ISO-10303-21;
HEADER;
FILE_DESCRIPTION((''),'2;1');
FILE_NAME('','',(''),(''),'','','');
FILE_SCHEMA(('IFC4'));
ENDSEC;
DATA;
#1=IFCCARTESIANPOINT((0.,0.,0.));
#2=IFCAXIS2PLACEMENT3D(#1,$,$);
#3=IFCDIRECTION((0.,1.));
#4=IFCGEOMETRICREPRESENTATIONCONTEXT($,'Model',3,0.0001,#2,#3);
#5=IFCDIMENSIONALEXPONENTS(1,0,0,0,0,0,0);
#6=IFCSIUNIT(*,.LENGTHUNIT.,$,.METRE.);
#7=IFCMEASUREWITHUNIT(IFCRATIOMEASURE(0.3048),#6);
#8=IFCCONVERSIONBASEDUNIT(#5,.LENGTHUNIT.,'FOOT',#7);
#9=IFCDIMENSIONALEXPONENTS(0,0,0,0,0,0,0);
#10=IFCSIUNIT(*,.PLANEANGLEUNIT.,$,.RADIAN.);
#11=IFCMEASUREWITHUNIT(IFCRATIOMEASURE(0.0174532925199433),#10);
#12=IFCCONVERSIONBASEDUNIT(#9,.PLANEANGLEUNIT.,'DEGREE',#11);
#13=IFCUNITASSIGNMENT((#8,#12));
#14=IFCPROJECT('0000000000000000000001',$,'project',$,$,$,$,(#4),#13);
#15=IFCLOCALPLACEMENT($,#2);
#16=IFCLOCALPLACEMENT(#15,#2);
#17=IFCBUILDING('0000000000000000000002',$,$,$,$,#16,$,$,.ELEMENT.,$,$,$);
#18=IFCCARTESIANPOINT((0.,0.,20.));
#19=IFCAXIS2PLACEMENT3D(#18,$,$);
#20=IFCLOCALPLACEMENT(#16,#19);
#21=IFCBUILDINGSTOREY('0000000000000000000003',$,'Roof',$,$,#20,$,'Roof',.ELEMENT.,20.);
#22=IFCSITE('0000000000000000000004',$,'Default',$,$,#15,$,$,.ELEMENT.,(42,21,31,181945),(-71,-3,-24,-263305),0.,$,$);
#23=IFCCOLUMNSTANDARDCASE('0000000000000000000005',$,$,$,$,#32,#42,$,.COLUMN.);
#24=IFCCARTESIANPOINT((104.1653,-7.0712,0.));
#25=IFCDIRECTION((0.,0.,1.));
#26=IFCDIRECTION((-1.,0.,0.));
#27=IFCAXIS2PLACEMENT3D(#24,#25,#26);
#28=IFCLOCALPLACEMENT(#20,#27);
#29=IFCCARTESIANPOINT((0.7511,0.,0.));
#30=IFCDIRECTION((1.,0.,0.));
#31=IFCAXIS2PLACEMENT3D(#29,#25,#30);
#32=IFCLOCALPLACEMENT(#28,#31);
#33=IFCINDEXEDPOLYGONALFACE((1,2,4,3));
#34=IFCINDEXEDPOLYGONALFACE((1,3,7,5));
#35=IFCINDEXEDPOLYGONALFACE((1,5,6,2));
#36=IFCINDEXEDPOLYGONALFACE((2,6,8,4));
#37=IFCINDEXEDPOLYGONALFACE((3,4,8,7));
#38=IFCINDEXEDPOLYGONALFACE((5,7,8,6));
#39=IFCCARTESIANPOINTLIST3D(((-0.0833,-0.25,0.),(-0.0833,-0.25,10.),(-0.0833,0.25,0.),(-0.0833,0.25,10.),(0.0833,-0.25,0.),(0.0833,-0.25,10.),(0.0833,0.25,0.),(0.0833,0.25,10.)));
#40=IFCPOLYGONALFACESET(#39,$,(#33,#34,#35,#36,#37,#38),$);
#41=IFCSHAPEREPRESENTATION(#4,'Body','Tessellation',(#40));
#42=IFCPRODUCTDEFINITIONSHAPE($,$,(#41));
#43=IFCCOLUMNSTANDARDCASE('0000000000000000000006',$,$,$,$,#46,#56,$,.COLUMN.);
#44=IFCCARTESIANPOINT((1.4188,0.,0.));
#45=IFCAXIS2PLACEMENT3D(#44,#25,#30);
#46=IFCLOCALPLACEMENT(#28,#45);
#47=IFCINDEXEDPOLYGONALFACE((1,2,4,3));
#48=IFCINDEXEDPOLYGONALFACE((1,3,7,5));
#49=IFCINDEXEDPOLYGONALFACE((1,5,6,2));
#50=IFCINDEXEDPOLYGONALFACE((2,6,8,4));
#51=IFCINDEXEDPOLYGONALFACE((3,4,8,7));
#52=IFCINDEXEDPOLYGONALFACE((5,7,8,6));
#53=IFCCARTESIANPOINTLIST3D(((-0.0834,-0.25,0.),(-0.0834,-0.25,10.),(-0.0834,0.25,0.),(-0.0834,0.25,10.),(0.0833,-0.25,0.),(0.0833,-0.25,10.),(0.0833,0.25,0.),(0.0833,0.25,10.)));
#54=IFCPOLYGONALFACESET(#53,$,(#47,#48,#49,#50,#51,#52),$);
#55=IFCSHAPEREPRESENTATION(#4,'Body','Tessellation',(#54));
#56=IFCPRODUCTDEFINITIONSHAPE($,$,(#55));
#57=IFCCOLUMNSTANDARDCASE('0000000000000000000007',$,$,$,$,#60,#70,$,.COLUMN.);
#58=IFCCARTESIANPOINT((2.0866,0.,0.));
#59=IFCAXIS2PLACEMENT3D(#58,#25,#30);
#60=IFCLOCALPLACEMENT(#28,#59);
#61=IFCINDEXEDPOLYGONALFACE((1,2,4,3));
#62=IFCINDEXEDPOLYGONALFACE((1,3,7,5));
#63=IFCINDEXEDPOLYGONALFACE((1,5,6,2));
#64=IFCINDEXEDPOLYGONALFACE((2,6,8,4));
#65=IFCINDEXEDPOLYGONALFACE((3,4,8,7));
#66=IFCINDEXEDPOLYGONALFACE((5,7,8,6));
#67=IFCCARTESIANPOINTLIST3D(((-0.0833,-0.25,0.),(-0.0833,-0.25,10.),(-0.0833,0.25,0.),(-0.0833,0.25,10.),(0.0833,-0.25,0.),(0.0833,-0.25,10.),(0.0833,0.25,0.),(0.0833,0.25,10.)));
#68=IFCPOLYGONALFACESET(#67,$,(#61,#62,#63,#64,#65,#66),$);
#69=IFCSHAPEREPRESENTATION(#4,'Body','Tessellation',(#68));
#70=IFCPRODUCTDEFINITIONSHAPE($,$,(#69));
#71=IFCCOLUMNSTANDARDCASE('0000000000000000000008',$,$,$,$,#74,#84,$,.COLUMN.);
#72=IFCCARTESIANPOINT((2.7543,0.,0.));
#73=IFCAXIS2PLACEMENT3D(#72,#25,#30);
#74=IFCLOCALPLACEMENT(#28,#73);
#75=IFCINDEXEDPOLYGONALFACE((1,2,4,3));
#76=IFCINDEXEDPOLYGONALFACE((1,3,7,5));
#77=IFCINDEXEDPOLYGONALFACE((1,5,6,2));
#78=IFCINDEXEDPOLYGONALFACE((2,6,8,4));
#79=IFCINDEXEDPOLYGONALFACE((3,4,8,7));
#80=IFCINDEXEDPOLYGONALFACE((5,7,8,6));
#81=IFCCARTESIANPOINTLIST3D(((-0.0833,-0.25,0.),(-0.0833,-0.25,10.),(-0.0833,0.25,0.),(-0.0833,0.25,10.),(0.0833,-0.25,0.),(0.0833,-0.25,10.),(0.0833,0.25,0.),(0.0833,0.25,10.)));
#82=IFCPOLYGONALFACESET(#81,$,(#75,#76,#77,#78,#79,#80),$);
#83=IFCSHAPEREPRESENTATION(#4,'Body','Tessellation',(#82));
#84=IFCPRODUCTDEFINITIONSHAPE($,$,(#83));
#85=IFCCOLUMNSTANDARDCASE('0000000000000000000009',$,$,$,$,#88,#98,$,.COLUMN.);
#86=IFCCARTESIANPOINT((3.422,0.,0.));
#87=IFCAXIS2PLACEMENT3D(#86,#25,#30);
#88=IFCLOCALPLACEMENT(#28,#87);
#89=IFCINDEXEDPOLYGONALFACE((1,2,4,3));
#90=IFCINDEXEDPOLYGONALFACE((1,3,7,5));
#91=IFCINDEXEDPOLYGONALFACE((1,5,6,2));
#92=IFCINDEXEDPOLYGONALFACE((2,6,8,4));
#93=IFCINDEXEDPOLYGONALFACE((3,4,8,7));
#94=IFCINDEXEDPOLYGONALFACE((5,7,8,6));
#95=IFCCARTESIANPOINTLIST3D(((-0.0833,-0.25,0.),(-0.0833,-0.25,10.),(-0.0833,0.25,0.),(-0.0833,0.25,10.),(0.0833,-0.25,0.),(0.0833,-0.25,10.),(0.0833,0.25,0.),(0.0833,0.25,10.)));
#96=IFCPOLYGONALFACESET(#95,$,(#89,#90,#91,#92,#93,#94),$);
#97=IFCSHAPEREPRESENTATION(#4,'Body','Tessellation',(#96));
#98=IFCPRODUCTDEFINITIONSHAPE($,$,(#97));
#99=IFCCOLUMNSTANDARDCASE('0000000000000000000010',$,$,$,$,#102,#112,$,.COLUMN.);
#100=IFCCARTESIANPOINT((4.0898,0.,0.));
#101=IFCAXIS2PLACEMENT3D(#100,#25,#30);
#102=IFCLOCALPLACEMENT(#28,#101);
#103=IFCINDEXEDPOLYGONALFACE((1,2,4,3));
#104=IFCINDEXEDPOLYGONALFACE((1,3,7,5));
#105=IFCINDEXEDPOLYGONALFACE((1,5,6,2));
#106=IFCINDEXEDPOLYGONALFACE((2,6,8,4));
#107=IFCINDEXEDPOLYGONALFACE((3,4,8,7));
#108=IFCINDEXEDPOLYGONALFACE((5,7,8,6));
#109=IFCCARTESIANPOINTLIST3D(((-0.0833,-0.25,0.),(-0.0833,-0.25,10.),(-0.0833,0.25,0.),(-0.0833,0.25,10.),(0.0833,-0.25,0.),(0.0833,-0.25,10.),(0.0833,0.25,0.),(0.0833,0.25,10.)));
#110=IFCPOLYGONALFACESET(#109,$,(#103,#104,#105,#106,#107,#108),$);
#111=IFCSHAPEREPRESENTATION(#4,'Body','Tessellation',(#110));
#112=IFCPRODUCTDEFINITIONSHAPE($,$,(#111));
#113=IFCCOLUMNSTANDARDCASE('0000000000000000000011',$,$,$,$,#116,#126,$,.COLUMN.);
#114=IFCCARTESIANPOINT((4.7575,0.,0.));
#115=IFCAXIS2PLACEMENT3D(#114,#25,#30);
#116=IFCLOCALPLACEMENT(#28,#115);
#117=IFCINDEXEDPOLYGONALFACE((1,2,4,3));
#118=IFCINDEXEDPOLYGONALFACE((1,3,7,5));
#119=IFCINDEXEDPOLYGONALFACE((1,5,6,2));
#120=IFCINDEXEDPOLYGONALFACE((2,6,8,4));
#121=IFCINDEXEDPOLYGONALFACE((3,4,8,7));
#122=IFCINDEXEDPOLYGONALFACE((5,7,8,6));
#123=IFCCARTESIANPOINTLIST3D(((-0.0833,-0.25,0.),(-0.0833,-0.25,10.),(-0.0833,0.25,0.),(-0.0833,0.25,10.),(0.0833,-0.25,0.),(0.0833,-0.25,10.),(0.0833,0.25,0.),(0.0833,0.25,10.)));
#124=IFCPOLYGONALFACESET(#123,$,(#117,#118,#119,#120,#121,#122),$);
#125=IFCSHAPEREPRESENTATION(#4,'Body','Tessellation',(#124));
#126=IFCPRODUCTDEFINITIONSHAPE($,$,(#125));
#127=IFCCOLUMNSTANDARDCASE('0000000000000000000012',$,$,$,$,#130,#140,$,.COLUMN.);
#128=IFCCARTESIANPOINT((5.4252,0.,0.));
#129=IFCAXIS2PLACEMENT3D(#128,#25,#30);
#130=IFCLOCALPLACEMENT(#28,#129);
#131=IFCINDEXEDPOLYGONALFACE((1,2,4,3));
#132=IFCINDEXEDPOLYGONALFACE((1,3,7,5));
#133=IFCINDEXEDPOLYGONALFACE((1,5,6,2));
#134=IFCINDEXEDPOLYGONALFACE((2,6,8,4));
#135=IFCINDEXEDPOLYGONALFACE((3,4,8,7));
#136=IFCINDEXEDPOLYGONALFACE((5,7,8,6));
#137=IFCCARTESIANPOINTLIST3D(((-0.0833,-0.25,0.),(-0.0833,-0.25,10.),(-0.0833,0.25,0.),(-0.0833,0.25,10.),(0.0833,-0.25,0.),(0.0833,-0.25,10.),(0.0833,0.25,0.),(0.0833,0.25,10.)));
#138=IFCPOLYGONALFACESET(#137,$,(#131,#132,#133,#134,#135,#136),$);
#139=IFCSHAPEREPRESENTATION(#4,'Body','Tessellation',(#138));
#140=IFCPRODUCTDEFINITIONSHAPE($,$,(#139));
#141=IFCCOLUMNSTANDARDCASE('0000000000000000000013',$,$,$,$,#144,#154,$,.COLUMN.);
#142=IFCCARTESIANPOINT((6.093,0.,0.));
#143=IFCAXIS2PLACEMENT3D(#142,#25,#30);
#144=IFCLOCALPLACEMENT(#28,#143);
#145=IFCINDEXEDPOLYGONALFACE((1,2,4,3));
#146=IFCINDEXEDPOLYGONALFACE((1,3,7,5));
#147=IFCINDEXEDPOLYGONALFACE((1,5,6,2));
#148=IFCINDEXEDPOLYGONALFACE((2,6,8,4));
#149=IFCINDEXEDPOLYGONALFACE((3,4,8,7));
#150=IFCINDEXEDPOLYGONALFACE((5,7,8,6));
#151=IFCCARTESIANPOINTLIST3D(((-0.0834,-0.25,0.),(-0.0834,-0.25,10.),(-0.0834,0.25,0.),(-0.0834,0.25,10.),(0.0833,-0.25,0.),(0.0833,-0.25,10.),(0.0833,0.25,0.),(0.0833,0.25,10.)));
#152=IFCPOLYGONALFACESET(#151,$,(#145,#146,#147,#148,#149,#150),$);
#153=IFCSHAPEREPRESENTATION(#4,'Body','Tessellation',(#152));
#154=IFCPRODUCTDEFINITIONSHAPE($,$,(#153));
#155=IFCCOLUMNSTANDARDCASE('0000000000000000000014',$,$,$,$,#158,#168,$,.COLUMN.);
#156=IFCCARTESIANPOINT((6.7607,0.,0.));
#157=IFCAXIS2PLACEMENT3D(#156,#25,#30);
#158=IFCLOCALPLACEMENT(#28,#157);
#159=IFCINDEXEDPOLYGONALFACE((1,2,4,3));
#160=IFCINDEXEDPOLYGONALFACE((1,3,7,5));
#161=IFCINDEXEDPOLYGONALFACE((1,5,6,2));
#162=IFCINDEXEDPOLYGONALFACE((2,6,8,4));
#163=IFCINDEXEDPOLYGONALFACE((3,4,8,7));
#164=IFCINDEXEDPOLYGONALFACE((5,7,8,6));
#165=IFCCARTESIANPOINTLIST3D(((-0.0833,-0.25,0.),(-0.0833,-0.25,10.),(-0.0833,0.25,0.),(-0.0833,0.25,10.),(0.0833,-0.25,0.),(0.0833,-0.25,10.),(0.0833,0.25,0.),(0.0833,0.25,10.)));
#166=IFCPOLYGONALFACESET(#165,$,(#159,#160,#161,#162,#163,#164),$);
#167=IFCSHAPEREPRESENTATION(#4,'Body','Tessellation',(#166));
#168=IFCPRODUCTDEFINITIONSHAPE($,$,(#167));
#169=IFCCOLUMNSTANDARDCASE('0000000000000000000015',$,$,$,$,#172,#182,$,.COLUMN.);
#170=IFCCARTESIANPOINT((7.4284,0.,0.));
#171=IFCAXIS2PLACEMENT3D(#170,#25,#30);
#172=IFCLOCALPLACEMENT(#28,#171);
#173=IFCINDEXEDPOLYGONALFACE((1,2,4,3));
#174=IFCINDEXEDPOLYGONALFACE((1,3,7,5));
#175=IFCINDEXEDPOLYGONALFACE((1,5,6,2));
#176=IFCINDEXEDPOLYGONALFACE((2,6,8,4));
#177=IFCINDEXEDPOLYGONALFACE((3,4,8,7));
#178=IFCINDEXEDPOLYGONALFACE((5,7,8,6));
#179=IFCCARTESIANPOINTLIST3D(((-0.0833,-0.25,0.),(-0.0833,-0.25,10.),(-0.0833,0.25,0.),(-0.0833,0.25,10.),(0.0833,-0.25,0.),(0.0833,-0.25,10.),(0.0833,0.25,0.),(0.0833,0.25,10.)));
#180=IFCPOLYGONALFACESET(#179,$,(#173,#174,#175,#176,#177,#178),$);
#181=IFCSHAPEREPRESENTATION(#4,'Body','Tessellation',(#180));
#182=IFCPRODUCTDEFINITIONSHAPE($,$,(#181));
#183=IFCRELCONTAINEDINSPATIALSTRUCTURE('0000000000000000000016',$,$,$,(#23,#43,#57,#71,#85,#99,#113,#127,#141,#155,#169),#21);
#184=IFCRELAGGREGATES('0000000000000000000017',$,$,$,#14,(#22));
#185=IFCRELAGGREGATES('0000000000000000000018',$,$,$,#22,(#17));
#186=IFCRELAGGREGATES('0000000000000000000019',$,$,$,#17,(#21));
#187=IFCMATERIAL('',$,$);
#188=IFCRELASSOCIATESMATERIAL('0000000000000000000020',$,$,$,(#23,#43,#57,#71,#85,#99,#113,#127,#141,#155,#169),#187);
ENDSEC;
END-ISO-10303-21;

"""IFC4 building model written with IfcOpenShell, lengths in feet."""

from ifc_helpers import new_model, entity, si_unit, converted_unit, direction, frame, origin, place, context, project, spatial, rectangle, extrude, material, element, save


model = new_model("IFC4")

# Units and contexts
model_context = context("Model", 3, precision=0.0001, world=origin(), true_north=direction((0.0, 1.0)))
ifc_project = project(units=[converted_unit("LENGTHUNIT", "FOOT", entity("IfcRatioMeasure", 0.3048), si_unit("LENGTHUNIT", "METRE"), dimensions=[1, 0, 0, 0, 0, 0, 0]), converted_unit("PLANEANGLEUNIT", "DEGREE", entity("IfcRatioMeasure", 0.0174532925199433), si_unit("PLANEANGLEUNIT", "RADIAN"), dimensions=[0, 0, 0, 0, 0, 0, 0])], contexts=[model_context])

# Site, building, storey
site_placement = place(None, origin())
site = spatial("IfcSite", under=ifc_project, at=site_placement, Name="Default", CompositionType="ELEMENT", RefLatitude=(42, 21, 31, 181945), RefLongitude=(-71, -3, -24, -263305), RefElevation=0.0)
building_placement = place(site_placement, origin())
building = spatial("IfcBuilding", under=site, at=building_placement, CompositionType="ELEMENT")
storey_placement = place(building_placement, frame((0.0, 0.0, 20.0)))
storey = spatial("IfcBuildingStorey", under=building, at=storey_placement, Name="Roof", LongName="Roof", CompositionType="ELEMENT", Elevation=20.0)

# Columns
ifc_material_1 = material(Name="")
placement = place(storey_placement, frame((104.1653, -7.0712, 0.0), z_axis=(0.0, 0.0, 1.0), x_axis=(-1.0, 0.0, 0.0)))
for number, where, z_axis, x_axis in (
    (1, (0.7511, 0.0, 0.0), (0.0, 0.0, 1.0), (1.0, 0.0, 0.0)),
    (2, (1.4188, 0.0, 0.0), (0.0, 0.0, 1.0), (1.0, 0.0, 0.0)),
    (3, (2.0866, 0.0, 0.0), (0.0, 0.0, 1.0), (1.0, 0.0, 0.0)),
    (4, (2.7543, 0.0, 0.0), (0.0, 0.0, 1.0), (1.0, 0.0, 0.0)),
    (5, (3.422, 0.0, 0.0), (0.0, 0.0, 1.0), (1.0, 0.0, 0.0)),
    (6, (4.0898, 0.0, 0.0), (0.0, 0.0, 1.0), (1.0, 0.0, 0.0)),
    (7, (4.7575, 0.0, 0.0), (0.0, 0.0, 1.0), (1.0, 0.0, 0.0)),
    (8, (5.4252, 0.0, 0.0), (0.0, 0.0, 1.0), (1.0, 0.0, 0.0)),
    (9, (6.093, 0.0, 0.0), (0.0, 0.0, 1.0), (1.0, 0.0, 0.0)),
    (10, (6.7607, 0.0, 0.0), (0.0, 0.0, 1.0), (1.0, 0.0, 0.0)),
    (11, (7.4284, 0.0, 0.0), (0.0, 0.0, 1.0), (1.0, 0.0, 0.0)),
):
    element("IfcColumnStandardCase", number, at=place(placement, frame(where, z_axis=z_axis, x_axis=x_axis)), inside=storey, material=ifc_material_1, PredefinedType="COLUMN", context=model_context, shape_type="SweptSolid", body=[
        extrude(rectangle(XDim=0.1667, YDim=0.5), origin(), (0.0, 0.0, 1.0), 10.0),
    ])

save(model, "model.ifc")
